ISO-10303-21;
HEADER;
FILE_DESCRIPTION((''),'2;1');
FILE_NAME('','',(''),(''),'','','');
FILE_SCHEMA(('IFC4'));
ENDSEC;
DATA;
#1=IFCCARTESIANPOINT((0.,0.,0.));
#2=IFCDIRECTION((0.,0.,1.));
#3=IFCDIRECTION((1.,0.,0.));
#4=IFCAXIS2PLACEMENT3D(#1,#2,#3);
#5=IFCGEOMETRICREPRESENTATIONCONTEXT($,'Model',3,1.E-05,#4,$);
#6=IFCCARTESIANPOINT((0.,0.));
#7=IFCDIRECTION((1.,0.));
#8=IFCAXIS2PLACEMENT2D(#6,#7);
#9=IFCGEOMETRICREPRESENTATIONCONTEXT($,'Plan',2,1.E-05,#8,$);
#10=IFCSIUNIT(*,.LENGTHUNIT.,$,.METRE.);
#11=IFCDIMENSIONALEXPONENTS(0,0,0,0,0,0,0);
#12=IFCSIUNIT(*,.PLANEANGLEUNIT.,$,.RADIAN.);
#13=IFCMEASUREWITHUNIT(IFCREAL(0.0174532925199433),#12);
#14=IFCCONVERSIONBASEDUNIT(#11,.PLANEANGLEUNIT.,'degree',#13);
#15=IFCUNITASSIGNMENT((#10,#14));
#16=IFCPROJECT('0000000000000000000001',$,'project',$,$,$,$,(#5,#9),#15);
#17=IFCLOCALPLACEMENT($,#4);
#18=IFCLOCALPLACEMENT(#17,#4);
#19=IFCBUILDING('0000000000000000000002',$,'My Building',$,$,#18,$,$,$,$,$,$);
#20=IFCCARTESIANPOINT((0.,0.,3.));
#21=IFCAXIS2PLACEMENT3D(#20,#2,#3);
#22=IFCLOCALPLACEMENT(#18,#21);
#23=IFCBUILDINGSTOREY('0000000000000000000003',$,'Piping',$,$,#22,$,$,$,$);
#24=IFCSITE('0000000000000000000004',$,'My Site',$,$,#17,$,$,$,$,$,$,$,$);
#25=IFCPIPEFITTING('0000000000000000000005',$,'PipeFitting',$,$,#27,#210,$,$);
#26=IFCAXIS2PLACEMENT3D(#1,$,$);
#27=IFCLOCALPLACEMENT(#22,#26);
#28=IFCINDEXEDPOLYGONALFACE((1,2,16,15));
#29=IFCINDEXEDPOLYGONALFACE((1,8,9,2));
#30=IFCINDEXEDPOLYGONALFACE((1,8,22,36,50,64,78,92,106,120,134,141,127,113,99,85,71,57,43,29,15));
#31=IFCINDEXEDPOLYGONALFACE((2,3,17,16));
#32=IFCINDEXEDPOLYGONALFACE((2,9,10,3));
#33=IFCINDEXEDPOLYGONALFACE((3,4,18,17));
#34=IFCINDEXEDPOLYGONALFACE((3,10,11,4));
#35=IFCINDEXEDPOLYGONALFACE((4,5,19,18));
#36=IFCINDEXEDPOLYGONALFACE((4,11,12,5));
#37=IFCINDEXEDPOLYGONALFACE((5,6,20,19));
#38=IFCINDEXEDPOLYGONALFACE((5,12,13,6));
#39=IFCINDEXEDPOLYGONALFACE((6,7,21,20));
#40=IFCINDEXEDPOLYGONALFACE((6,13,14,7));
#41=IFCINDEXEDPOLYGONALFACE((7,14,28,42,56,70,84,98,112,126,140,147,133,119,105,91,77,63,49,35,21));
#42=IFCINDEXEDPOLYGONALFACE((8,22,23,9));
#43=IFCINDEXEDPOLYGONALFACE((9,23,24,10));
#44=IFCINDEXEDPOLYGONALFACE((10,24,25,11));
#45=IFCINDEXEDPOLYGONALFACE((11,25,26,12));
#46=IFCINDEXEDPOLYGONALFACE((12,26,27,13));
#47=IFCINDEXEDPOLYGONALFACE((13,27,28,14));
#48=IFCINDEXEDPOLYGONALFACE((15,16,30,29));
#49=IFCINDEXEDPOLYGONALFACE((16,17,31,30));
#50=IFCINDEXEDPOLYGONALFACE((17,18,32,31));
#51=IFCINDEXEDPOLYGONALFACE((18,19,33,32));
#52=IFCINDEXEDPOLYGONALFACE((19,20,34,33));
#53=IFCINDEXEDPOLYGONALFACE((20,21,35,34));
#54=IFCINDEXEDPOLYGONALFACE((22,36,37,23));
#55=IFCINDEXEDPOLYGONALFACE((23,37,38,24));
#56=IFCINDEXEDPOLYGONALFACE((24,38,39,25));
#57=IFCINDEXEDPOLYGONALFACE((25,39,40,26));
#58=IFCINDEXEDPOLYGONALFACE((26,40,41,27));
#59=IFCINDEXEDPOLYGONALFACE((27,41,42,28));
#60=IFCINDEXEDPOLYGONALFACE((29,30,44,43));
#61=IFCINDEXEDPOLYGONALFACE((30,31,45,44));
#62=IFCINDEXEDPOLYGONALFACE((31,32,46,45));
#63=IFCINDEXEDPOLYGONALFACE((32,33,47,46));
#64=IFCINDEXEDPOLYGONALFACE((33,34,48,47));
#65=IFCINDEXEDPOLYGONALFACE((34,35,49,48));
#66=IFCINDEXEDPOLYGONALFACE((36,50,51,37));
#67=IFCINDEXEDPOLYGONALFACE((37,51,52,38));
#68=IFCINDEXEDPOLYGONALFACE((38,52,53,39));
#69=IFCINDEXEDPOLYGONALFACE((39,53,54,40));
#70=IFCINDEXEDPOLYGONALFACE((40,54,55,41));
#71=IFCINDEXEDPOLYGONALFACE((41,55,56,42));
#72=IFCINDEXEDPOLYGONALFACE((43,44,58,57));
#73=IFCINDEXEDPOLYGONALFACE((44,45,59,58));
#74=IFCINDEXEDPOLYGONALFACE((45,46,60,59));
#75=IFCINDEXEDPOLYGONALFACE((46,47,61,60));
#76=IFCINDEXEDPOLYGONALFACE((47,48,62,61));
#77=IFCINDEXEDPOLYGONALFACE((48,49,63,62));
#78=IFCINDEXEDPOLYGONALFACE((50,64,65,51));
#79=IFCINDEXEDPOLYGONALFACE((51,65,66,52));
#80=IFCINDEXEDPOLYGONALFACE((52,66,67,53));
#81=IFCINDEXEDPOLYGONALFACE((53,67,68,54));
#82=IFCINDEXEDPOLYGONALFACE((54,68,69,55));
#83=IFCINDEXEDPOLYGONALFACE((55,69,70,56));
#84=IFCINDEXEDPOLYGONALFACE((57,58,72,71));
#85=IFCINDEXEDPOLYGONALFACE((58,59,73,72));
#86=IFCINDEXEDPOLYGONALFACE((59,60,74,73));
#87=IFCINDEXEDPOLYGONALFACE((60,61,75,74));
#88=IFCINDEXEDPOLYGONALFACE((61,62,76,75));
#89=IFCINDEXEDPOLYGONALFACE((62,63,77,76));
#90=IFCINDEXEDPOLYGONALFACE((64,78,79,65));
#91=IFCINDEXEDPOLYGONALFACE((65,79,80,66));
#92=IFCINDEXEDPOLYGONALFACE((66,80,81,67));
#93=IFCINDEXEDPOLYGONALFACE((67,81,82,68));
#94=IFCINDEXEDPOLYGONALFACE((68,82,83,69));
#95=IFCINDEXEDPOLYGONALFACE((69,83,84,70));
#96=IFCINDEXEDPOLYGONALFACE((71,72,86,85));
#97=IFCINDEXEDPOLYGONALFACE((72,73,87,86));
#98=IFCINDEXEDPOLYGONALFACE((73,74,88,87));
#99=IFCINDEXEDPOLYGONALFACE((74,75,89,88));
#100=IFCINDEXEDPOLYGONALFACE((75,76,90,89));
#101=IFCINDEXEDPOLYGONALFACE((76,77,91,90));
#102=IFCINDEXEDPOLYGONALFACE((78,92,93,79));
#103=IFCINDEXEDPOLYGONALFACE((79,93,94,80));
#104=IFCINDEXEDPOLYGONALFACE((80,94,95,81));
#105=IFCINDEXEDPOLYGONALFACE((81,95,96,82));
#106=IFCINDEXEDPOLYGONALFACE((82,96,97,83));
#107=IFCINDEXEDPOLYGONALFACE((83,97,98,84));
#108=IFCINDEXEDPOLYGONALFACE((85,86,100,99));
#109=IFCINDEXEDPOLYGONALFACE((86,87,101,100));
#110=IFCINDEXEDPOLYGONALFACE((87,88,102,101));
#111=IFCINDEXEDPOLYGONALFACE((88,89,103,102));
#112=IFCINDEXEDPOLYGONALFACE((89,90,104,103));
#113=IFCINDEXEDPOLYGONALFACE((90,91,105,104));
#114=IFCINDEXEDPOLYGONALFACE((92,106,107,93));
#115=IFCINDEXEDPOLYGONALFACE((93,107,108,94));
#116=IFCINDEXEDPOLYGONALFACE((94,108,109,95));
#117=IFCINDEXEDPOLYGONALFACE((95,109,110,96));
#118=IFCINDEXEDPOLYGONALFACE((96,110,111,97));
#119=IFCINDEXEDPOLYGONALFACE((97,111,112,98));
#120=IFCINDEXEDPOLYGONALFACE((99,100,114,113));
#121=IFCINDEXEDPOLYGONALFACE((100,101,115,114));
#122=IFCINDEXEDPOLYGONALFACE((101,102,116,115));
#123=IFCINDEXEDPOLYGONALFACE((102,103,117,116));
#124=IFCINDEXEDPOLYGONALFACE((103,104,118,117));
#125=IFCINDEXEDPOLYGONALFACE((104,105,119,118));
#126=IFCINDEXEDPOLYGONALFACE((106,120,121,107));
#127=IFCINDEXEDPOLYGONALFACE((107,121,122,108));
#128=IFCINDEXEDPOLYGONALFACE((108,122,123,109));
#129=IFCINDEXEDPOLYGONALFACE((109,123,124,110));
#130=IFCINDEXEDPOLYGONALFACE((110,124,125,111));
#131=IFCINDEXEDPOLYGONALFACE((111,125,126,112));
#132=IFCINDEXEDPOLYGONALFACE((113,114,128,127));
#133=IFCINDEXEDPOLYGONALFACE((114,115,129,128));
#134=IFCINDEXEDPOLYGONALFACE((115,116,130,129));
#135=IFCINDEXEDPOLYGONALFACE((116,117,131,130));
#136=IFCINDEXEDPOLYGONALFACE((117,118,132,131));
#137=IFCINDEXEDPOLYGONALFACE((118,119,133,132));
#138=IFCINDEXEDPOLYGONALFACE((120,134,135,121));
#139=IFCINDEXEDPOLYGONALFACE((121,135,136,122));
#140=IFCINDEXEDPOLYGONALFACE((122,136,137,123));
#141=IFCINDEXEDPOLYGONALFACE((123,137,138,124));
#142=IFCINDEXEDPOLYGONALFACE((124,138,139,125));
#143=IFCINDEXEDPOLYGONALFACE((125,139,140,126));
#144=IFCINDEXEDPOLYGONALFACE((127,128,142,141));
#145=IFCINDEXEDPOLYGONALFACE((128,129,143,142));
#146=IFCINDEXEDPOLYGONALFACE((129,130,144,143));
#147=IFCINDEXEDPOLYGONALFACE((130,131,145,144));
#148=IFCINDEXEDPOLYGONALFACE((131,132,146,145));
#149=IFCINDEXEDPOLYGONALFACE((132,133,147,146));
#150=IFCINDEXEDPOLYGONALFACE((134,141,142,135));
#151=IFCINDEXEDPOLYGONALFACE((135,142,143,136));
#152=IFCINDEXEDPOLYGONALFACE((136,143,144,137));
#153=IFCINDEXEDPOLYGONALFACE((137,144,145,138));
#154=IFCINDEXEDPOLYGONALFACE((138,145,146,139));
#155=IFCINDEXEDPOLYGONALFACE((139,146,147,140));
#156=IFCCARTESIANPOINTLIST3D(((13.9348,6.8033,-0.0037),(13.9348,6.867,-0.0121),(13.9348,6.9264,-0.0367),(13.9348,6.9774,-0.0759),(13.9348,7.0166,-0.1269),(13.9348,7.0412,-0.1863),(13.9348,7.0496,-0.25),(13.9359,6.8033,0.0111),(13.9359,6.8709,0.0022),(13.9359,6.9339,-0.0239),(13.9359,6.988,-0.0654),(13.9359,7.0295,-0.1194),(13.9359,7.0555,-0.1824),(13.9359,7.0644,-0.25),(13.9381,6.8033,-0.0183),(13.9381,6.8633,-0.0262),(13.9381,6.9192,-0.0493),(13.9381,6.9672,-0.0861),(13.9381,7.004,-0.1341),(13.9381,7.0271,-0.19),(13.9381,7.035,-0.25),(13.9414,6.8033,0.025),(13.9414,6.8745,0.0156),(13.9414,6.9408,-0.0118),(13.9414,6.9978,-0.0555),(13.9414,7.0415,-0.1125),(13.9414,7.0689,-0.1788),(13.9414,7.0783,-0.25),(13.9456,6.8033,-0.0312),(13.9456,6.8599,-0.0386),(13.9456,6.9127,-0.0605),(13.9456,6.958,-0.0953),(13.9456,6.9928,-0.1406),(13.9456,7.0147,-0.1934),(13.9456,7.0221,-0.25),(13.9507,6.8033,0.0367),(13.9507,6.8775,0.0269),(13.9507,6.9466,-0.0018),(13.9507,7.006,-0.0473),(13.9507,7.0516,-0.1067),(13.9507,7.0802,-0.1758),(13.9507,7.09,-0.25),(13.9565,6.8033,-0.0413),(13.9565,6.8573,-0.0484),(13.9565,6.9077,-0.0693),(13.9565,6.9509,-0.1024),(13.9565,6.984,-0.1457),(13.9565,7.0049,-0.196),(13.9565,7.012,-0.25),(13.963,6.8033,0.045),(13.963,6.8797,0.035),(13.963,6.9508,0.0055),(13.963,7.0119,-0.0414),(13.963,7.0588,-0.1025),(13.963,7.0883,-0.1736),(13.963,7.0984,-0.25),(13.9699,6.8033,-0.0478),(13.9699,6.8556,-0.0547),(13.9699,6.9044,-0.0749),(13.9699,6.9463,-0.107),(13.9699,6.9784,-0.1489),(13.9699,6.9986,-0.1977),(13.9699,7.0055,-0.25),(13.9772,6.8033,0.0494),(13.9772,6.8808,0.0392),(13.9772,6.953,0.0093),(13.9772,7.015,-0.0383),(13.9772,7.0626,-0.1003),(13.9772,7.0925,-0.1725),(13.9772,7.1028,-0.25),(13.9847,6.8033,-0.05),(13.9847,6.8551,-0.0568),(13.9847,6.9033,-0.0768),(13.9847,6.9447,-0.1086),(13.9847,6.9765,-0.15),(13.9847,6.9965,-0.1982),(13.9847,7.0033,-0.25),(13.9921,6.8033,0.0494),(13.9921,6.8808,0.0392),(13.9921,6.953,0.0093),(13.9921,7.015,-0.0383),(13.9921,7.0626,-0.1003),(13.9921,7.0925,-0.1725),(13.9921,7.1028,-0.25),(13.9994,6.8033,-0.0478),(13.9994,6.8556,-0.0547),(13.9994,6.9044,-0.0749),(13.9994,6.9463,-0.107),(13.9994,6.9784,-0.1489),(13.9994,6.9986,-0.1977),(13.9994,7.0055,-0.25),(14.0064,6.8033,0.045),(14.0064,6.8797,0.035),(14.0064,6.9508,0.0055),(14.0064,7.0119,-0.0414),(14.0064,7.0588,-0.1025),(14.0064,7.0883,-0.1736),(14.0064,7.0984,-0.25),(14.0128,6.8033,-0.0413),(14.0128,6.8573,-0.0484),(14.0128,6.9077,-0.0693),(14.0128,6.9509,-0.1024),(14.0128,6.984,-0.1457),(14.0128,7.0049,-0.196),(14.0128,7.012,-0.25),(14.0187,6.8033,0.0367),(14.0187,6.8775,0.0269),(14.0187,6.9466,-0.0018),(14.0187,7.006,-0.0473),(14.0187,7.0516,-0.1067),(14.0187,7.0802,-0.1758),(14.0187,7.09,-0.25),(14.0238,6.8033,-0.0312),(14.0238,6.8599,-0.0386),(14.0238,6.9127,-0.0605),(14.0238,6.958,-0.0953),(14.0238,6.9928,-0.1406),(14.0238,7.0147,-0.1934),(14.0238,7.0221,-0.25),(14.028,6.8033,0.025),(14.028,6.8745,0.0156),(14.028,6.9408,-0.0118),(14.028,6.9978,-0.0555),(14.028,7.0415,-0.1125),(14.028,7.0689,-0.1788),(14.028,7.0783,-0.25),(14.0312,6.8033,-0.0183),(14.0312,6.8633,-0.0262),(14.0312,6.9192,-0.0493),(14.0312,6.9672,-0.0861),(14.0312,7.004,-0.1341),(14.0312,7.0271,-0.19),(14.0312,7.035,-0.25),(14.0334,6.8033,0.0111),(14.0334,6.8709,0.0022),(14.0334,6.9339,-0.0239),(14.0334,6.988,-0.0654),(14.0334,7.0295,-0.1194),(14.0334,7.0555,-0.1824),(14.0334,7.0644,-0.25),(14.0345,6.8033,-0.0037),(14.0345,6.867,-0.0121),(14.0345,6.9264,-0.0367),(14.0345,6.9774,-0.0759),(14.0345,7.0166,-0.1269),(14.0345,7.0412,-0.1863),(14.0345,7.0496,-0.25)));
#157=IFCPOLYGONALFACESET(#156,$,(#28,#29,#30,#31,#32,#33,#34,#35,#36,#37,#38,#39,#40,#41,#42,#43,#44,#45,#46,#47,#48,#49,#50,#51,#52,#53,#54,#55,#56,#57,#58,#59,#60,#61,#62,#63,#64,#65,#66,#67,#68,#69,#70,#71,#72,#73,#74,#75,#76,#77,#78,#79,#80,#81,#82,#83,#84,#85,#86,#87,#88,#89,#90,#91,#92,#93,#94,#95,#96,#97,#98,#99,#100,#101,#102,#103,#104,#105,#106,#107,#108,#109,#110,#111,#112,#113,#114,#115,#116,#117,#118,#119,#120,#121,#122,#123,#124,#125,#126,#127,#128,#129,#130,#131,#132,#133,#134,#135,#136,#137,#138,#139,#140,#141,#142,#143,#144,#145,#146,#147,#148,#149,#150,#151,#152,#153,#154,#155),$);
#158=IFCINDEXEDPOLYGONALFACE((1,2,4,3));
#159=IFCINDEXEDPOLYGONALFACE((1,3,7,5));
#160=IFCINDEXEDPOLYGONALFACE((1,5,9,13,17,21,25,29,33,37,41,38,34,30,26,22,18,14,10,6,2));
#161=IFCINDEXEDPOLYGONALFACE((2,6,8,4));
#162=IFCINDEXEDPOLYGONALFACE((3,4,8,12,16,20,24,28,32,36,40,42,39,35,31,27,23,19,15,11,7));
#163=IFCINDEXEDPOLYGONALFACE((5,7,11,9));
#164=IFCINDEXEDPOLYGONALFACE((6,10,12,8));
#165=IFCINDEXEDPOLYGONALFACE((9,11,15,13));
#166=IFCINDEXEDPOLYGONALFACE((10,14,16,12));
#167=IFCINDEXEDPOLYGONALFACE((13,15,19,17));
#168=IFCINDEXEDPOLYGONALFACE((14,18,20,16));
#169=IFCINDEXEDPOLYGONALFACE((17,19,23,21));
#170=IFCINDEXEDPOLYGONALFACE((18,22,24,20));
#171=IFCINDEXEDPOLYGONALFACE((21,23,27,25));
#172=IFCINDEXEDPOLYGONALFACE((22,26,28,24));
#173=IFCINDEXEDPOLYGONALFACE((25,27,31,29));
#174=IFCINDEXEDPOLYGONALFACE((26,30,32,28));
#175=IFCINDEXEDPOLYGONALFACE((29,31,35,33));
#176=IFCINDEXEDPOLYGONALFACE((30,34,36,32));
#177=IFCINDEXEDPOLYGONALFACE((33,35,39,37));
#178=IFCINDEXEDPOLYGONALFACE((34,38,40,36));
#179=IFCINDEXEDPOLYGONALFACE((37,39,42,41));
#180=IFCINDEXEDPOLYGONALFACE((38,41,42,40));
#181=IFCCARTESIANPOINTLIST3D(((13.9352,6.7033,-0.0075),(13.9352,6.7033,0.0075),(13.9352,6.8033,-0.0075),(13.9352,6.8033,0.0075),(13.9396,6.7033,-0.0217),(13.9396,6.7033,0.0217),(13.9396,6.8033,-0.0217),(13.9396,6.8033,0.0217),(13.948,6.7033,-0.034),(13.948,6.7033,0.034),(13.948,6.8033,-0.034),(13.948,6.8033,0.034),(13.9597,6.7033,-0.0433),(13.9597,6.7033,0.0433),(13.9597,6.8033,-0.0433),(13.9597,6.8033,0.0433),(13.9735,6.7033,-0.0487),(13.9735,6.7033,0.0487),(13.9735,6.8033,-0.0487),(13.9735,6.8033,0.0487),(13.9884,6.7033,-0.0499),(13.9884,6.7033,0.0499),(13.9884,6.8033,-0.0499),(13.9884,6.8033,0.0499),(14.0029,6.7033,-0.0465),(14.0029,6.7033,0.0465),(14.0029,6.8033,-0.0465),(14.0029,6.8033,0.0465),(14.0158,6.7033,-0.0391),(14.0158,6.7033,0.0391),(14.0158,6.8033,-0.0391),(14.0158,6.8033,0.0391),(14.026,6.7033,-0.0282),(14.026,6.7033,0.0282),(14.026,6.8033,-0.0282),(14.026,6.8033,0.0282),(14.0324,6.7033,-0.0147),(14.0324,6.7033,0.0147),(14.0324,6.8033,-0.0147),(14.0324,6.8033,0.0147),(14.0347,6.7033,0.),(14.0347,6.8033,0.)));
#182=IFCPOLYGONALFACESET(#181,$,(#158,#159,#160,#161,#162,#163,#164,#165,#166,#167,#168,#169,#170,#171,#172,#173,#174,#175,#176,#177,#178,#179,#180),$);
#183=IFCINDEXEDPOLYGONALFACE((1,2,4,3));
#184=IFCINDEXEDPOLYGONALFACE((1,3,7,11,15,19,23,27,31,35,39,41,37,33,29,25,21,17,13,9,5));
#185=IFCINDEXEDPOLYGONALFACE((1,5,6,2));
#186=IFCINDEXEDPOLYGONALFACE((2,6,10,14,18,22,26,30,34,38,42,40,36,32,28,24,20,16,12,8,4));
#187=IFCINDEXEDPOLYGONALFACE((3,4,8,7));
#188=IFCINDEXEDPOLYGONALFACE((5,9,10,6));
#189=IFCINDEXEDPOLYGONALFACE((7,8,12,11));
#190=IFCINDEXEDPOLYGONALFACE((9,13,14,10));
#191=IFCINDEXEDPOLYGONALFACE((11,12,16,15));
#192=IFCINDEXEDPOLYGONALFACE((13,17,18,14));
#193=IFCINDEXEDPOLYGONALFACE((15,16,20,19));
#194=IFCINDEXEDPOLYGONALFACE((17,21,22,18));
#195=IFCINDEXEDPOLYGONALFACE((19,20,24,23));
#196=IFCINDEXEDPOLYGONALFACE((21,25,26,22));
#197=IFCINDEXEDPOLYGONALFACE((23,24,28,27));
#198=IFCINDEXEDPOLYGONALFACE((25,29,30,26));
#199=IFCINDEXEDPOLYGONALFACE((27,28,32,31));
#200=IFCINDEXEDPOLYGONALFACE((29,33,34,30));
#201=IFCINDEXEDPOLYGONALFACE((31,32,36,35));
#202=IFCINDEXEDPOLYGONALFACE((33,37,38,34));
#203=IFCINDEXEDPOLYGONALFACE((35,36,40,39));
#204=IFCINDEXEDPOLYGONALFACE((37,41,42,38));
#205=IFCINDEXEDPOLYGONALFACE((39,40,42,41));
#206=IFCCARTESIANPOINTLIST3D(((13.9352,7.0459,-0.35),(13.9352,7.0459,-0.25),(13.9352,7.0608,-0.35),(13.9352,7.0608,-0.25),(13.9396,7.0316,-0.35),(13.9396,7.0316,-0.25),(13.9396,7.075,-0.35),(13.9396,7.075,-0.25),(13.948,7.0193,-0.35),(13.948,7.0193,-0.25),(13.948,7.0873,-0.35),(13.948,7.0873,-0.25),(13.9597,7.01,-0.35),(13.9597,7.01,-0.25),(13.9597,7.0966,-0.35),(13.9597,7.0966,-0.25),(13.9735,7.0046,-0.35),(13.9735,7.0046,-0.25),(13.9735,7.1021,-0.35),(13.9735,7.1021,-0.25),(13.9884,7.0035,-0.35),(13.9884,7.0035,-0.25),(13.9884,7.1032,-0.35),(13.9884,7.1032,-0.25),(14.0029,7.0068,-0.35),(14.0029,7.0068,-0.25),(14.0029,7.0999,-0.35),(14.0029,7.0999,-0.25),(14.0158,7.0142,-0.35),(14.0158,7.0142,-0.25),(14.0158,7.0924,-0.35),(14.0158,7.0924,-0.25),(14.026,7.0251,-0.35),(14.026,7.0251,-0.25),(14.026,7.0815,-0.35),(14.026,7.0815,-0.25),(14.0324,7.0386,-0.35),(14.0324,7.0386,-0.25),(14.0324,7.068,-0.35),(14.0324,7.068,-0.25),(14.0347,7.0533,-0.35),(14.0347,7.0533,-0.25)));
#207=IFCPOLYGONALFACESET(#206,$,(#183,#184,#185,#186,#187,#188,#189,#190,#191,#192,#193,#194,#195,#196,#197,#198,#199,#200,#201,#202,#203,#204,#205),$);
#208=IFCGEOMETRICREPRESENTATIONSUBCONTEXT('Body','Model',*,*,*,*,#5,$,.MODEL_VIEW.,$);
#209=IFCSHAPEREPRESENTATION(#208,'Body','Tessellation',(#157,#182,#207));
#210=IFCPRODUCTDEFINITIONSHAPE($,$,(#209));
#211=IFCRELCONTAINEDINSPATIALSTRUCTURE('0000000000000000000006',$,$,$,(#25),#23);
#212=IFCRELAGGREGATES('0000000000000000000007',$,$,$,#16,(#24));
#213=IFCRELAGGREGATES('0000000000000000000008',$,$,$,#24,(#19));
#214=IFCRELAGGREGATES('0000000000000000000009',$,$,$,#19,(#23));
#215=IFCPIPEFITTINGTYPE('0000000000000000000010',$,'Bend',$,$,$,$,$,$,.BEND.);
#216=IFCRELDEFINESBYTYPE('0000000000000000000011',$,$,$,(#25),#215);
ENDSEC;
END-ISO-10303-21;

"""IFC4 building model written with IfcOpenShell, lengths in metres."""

from ifc_helpers import new_model, entity, si_unit, converted_unit, frame, origin_with_axes, origin_2d_with_axis, place, context, subcontext, project, spatial, circle, extrude, source, transform, mapped, type_object, type_shapes, element, save


model = new_model("IFC4")

# Units and contexts
model_context = context("Model", 3, precision=1e-05, world=origin_with_axes())
plan_context = context("Plan", 2, precision=1e-05, world=origin_2d_with_axis())
body_context = subcontext(model_context, "Body", "Model", "MODEL_VIEW")
ifc_project = project(units=[si_unit("LENGTHUNIT", "METRE"), converted_unit("PLANEANGLEUNIT", "degree", entity("IfcReal", 0.0174532925199433), si_unit("PLANEANGLEUNIT", "RADIAN"), dimensions=[0, 0, 0, 0, 0, 0, 0])], contexts=[model_context, plan_context])

# Site, building, storey
site_placement = place(None, origin_with_axes())
site = spatial("IfcSite", under=ifc_project, at=site_placement, Name="My Site")
building_placement = place(site_placement, origin_with_axes())
building = spatial("IfcBuilding", under=site, at=building_placement, Name="My Building")
storey_placement = place(building_placement, frame((0.0, 0.0, 3.0), z_axis=(0.0, 0.0, 1.0), x_axis=(1.0, 0.0, 0.0)))
storey = spatial("IfcBuildingStorey", under=building, at=storey_placement, Name="Piping")

# Shared definitions
pipe_fitting_type = type_object("IfcPipeFittingType", Name="Bend", PredefinedType="BEND")
shared_shape = source(origin_with_axes(), body_context, "Body", "SolidModel", [
    entity("IfcSweptDiskSolid", entity("IfcIndexedPolyCurve", entity("IfcCartesianPointList3D", [[0.0, 0.0, -0.1], [0.0, -0.0732, -0.2768], [0.0, -0.25, -0.35]]), [entity("IfcArcIndex", [1, 2, 3])]), 0.05),
    extrude(circle(Radius=0.05), origin_with_axes(), (0.0, 0.0, -1.0), 0.1),
    extrude(circle(Radius=0.05), frame((0.0, -0.25, -0.35), z_axis=(0.0, -1.0, 0.0), x_axis=(1.0, 0.0, 0.0)), (0.0, 0.0, 1.0), 0.1),
])
type_shapes(pipe_fitting_type, [shared_shape])

# Pipe fitting
for number, where, z_axis, x_axis, name in (
    (1, (13.9847, 6.7033, 0.0), (0.0, -1.0, 0.0), (1.0, 0.0, 0.0), "PipeFitting"),
):
    element("IfcPipeFitting", number, at=place(storey_placement, frame(where, z_axis=z_axis, x_axis=x_axis)), inside=storey, type_object=pipe_fitting_type, Name=name, context=body_context, shape_type="MappedRepresentation", body=[
        mapped(shared_shape, transform((0.0, 0.0, 0.0), x_axis=(1.0, 0.0, 0.0), y_axis=(0.0, 1.0, 0.0), z_axis=(0.0, 0.0, 1.0), scale=1.0)),
    ])

save(model, "model.ifc")
